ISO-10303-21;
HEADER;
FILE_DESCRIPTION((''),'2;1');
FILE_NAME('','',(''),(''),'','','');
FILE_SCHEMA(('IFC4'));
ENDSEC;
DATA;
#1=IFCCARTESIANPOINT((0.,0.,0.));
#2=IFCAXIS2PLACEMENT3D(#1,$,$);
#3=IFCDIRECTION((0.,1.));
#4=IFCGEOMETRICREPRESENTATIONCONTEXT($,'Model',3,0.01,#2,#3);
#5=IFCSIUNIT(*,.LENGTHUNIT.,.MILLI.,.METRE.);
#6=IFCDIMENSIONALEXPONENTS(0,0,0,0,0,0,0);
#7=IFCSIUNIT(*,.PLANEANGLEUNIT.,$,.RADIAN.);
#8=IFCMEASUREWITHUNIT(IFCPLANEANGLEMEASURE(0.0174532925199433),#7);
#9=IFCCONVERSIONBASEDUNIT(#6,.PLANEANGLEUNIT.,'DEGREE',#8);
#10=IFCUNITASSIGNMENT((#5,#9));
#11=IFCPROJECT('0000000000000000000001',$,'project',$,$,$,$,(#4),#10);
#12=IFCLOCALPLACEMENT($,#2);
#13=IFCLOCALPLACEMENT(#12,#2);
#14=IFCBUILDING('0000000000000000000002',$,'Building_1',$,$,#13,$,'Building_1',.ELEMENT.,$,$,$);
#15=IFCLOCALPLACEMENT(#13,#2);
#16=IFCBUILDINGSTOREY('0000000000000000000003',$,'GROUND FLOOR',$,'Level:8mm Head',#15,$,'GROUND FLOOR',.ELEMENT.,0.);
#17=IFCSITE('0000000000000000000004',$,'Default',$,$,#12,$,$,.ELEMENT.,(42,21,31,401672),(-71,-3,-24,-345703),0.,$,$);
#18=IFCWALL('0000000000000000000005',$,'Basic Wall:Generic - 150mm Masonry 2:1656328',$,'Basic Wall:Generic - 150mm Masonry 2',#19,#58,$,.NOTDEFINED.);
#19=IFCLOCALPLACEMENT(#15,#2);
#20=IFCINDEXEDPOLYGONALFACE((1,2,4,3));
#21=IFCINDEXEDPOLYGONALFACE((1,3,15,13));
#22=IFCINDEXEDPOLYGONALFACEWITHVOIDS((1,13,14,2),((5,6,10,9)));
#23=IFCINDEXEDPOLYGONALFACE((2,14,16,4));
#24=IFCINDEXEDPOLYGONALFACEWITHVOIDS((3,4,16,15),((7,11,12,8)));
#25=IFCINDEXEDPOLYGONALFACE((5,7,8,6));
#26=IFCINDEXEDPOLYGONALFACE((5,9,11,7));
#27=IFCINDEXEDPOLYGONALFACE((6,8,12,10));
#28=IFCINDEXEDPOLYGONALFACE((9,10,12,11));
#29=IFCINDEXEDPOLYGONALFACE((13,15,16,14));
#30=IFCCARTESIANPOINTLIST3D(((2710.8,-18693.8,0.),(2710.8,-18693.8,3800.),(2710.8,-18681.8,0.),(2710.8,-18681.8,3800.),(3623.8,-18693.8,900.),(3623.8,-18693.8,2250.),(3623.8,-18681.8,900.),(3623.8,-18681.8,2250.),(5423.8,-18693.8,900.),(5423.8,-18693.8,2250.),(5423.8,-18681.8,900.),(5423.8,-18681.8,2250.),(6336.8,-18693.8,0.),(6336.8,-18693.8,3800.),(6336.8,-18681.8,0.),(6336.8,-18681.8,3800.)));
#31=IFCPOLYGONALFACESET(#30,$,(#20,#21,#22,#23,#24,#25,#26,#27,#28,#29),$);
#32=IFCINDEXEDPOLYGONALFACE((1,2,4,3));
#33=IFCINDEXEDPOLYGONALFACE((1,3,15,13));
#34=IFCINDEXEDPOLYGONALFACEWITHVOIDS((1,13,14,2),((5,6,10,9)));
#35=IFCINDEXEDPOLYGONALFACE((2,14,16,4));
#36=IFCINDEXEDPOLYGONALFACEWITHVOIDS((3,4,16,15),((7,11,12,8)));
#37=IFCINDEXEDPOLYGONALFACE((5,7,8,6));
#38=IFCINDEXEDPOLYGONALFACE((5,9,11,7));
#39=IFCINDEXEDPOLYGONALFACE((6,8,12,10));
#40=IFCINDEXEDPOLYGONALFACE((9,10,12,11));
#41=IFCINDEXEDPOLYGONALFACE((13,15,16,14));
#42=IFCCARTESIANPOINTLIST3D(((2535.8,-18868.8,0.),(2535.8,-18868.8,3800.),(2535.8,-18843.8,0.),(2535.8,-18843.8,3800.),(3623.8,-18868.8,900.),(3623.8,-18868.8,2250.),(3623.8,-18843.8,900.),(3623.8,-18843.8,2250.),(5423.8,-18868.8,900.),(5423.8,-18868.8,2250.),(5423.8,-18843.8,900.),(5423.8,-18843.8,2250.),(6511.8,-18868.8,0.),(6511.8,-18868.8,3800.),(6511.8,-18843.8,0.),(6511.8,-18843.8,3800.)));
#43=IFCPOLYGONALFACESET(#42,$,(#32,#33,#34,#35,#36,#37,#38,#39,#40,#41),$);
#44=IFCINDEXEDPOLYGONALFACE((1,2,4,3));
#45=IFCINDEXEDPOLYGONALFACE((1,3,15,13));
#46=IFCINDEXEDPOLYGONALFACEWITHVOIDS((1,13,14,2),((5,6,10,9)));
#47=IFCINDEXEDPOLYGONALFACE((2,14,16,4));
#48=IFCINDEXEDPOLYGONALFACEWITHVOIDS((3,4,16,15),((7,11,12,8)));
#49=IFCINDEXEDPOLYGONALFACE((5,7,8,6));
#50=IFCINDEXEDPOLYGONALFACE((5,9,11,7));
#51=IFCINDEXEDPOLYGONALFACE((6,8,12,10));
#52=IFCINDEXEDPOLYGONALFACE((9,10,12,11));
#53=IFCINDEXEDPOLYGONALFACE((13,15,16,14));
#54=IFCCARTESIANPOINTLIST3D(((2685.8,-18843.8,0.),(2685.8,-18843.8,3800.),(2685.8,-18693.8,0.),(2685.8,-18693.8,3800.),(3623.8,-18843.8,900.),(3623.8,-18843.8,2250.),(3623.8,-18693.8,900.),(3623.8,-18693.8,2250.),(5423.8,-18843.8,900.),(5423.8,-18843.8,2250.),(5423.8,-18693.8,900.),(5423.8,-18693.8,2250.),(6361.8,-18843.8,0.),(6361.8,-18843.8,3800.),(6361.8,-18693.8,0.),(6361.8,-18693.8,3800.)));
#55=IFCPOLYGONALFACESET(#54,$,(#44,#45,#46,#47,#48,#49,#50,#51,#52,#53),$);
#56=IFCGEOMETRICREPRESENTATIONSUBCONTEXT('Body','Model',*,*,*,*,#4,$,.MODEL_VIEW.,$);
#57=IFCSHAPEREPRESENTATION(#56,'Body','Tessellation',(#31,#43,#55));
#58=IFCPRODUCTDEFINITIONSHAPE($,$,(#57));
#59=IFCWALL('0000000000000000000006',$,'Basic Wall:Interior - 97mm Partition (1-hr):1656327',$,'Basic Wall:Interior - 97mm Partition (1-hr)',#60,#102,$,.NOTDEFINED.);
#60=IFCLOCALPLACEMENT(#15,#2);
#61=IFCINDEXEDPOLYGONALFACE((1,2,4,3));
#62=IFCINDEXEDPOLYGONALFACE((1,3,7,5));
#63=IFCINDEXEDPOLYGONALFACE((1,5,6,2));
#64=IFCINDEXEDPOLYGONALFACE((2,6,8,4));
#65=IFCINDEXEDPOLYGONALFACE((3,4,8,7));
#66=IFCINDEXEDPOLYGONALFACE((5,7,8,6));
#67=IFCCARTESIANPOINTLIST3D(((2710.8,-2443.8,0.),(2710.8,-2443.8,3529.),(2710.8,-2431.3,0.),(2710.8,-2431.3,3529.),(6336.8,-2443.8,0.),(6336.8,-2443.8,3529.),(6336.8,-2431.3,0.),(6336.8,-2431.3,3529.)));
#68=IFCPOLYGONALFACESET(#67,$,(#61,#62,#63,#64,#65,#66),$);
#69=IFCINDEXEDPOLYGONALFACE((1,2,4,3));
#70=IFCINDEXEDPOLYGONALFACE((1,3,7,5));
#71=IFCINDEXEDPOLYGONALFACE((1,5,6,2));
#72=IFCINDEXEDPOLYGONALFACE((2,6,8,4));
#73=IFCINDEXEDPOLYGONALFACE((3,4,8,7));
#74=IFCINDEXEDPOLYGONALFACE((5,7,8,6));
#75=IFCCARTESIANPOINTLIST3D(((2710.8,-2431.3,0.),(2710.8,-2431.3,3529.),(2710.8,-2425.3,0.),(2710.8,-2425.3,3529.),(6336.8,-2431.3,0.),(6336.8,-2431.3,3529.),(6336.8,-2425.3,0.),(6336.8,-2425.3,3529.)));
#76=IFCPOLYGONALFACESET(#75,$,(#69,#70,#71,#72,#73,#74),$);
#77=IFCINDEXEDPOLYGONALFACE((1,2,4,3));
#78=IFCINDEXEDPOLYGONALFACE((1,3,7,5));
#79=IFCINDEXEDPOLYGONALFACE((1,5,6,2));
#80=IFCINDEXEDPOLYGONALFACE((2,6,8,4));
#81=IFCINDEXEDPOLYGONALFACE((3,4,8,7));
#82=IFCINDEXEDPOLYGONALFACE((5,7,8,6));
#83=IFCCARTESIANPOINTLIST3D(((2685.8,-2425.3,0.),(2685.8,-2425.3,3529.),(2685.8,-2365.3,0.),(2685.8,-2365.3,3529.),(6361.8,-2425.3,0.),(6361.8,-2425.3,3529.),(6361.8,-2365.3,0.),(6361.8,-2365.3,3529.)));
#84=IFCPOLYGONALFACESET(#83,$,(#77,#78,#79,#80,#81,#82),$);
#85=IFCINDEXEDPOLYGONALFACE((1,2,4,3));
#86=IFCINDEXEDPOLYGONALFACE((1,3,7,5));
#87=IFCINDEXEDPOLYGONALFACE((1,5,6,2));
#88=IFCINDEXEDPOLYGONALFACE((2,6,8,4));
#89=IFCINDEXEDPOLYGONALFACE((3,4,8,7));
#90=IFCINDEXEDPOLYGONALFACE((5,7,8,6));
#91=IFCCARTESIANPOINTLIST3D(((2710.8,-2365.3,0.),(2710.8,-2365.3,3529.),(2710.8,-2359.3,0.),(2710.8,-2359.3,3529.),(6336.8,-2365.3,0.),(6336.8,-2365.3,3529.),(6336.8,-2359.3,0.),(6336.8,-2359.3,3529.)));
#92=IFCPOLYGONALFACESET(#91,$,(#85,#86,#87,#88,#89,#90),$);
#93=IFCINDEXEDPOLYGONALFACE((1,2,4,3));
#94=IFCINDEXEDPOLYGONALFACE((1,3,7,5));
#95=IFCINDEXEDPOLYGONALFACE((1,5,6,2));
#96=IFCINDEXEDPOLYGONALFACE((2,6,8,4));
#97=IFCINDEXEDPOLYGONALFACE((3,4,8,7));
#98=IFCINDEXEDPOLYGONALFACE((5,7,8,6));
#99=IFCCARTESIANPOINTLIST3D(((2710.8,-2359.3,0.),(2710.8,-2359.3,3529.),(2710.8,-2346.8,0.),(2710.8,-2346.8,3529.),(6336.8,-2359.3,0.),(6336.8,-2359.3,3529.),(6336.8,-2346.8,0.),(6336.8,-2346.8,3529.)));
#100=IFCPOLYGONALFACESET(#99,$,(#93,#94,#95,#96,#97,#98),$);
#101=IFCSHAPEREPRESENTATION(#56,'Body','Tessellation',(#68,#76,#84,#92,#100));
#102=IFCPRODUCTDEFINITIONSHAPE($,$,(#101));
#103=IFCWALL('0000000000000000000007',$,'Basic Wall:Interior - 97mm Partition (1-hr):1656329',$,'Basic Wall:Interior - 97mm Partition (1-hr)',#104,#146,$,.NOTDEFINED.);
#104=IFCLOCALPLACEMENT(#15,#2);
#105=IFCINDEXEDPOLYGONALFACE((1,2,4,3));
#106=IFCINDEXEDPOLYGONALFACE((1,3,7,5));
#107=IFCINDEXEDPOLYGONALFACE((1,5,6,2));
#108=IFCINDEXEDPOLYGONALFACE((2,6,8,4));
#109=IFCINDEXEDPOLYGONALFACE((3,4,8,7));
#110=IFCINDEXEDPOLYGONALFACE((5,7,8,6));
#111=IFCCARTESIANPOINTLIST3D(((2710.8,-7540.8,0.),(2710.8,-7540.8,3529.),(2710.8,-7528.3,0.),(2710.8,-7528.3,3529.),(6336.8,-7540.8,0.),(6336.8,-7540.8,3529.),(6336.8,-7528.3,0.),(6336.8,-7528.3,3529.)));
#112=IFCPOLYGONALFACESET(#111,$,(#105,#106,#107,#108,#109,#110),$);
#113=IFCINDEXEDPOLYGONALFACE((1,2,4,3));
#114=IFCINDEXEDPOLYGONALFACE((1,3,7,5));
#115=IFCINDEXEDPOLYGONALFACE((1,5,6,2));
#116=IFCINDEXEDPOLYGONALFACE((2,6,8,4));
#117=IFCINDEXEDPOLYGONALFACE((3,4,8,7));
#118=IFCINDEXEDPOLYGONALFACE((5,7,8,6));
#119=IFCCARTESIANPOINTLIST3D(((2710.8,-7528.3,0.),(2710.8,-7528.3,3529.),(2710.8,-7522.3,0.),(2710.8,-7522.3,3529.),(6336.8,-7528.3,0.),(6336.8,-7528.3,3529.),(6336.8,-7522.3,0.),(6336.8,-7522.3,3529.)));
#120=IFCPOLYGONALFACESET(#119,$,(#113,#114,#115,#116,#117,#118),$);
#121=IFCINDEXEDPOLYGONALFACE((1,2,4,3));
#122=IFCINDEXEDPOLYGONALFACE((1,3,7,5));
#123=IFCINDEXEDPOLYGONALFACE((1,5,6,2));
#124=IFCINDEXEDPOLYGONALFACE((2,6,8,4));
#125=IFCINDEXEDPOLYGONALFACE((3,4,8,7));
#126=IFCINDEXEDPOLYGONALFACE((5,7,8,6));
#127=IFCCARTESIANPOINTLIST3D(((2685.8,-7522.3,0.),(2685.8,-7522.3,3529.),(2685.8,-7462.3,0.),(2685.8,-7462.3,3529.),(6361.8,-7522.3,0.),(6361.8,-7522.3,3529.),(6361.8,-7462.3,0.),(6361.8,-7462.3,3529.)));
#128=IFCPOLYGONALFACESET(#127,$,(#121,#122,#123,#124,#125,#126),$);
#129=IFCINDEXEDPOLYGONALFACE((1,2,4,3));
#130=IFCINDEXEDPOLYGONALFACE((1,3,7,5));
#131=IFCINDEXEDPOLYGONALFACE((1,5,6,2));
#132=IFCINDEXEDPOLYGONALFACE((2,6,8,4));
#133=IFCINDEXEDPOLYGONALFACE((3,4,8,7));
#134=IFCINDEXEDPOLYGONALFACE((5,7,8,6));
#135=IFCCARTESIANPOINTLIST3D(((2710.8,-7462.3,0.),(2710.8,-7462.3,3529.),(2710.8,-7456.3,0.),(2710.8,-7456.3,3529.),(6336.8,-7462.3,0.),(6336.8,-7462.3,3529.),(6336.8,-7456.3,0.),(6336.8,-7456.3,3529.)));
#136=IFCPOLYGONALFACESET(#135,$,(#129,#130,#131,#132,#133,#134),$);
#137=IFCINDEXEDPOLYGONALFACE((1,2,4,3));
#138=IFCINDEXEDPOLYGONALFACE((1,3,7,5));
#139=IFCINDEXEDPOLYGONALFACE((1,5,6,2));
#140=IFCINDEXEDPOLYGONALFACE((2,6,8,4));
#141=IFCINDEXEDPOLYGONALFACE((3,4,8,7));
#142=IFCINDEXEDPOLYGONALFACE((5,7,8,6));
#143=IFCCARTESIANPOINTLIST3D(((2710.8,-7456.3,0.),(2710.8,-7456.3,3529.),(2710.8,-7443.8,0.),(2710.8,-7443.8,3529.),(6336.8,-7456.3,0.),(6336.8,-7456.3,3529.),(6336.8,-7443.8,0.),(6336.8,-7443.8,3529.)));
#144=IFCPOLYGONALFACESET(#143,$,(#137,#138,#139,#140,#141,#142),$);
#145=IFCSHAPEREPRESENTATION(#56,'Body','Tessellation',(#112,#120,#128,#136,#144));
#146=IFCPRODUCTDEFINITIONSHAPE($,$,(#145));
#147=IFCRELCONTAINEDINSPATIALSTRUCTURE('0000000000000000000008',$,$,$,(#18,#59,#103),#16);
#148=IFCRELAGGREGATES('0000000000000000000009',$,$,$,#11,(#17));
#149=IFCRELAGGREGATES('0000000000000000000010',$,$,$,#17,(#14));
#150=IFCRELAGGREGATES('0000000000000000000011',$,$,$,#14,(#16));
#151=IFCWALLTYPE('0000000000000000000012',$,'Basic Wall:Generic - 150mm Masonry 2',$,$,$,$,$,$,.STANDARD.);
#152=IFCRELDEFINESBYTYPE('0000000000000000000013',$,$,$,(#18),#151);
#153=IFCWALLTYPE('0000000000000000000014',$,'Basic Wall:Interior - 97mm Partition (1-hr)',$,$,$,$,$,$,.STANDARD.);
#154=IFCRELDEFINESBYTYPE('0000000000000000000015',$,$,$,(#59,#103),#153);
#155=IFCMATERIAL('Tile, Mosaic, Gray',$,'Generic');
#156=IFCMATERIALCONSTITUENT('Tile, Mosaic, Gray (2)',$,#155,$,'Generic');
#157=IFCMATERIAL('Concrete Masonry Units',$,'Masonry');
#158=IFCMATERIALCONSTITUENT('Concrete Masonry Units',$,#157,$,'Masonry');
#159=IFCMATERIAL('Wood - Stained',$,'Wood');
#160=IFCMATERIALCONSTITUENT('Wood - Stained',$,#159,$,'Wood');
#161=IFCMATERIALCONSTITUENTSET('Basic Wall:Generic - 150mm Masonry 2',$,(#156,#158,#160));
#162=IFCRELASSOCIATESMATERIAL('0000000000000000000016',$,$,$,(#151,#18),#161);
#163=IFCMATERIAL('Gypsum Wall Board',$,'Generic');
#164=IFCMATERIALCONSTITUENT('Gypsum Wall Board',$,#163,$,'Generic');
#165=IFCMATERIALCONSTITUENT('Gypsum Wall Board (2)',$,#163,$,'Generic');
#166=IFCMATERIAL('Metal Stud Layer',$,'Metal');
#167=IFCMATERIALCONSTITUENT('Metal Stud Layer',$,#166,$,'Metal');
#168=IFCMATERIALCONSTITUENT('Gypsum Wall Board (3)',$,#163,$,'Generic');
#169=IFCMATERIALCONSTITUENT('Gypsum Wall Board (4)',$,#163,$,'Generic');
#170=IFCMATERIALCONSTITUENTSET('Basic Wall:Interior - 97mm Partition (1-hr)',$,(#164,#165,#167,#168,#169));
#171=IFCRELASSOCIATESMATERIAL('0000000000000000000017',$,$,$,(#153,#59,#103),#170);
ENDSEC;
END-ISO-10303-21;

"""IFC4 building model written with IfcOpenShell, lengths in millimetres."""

from ifc_helpers import new_model, entity, si_unit, converted_unit, direction, frame, origin, place, context, subcontext, project, spatial, indexed_curve, outline, extrude, material, constituent, constituent_set, type_object, element, save


model = new_model("IFC4")

# Units and contexts
model_context = context("Model", 3, precision=0.01, world=origin(), true_north=direction((0.0, 1.0)))
body_context = subcontext(model_context, "Body", "Model", "MODEL_VIEW")
ifc_project = project(units=[si_unit("LENGTHUNIT", "METRE", prefix="MILLI"), converted_unit("PLANEANGLEUNIT", "DEGREE", entity("IfcPlaneAngleMeasure", 0.0174532925199433), si_unit("PLANEANGLEUNIT", "RADIAN"), dimensions=[0, 0, 0, 0, 0, 0, 0])], contexts=[model_context])

# Site, building, storey
site_placement = place(None, origin())
site = spatial("IfcSite", under=ifc_project, at=site_placement, Name="Default", CompositionType="ELEMENT", RefLatitude=(42, 21, 31, 401672), RefLongitude=(-71, -3, -24, -345703), RefElevation=0.0)
building_placement = place(site_placement, origin())
building = spatial("IfcBuilding", under=site, at=building_placement, Name="Building_1", LongName="Building_1", CompositionType="ELEMENT")
storey_placement = place(building_placement, origin())
storey = spatial("IfcBuildingStorey", under=building, at=storey_placement, Name="GROUND FLOOR", ObjectType="Level:8mm Head", LongName="GROUND FLOOR", CompositionType="ELEMENT", Elevation=0.0)

# Shared definitions
ifc_material_1 = material(Name="Tile, Mosaic, Gray", Category="Generic")
ifc_constituent_1 = constituent(ifc_material_1, Name="Tile, Mosaic, Gray (2)", Category="Generic")
ifc_material_2 = material(Name="Concrete Masonry Units", Category="Masonry")
ifc_constituent_2 = constituent(ifc_material_2, Name="Concrete Masonry Units", Category="Masonry")
ifc_material_3 = material(Name="Wood - Stained", Category="Wood")
ifc_constituent_3 = constituent(ifc_material_3, Name="Wood - Stained", Category="Wood")
ifc_constituent_set_1 = constituent_set(constituents=[ifc_constituent_1, ifc_constituent_2, ifc_constituent_3], Name="Basic Wall:Generic - 150mm Masonry 2")
wall_type_1 = type_object("IfcWallType", Name="Basic Wall:Generic - 150mm Masonry 2", PredefinedType="STANDARD", material=ifc_constituent_set_1)

# Wall, opening
wall_1_placement = place(storey_placement, frame((2710.8, -18775.3, 0.0)))
wall_1 = element("IfcWall", 1, at=wall_1_placement, inside=storey, type_object=wall_type_1, material=ifc_constituent_set_1, Name="Basic Wall:Generic - 150mm Masonry 2:1656328", ObjectType="Basic Wall:Generic - 150mm Masonry 2", PredefinedType="NOTDEFINED", context=body_context, shape_type="SweptSolid", body=[
    extrude(outline(indexed_curve([(-1900.0, -1813.0), (1900.0, -1813.0), (1900.0, 1813.0), (-1900.0, 1813.0), (-1900.0, -1813.0)], self_intersect=False), holes=[indexed_curve([(350.0, 900.0), (350.0, -900.0), (-1000.0, -900.0), (-1000.0, 900.0), (350.0, 900.0)], self_intersect=False)]), frame((1813.0, 81.5, 1900.0), z_axis=(0.0, 1.0, 0.0), x_axis=(0.0, 0.0, 1.0)), (0.0, 0.0, 1.0), 12.0),
    extrude(outline(indexed_curve([(-1900.0, -1988.0), (1900.0, -1988.0), (1900.0, 1988.0), (-1900.0, 1988.0), (-1900.0, -1988.0)], self_intersect=False), holes=[indexed_curve([(350.0, 900.0), (350.0, -900.0), (-1000.0, -900.0), (-1000.0, 900.0), (350.0, 900.0)], self_intersect=False)]), frame((1813.0, -93.5, 1900.0), z_axis=(0.0, 1.0, 0.0), x_axis=(0.0, 0.0, 1.0)), (0.0, 0.0, 1.0), 25.0),
    extrude(outline(indexed_curve([(-1900.0, -1838.0), (1900.0, -1838.0), (1900.0, 1838.0), (-1900.0, 1838.0), (-1900.0, -1838.0)], self_intersect=False), holes=[indexed_curve([(350.0, 900.0), (350.0, -900.0), (-1000.0, -900.0), (-1000.0, 900.0), (350.0, 900.0)], self_intersect=False)]), frame((1813.0, -68.5, 1900.0), z_axis=(0.0, 1.0, 0.0), x_axis=(0.0, 0.0, 1.0)), (0.0, 0.0, 1.0), 150.0),
])
opening_1_placement = place(wall_1_placement, frame((2713.0, 93.5, 900.0)))
element("IfcOpeningElement", 2, at=opening_1_placement, cuts=wall_1, PredefinedType="OPENING", context=body_context, shape_type="SweptSolid", body=[
    extrude(outline(indexed_curve([(1350.0, 0.0), (1350.0, 1800.0), (0.0, 1800.0), (0.0, 0.0), (1350.0, 0.0)], self_intersect=False)), frame((0.0, 0.0, 0.0), z_axis=(0.0, -1.0, 0.0), x_axis=(0.0, 0.0, 1.0)), (0.0, 0.0, 1.0), 187.0),
])

# Walls
ifc_material_4 = material(Name="Gypsum Wall Board", Category="Generic")
ifc_constituent_4 = constituent(ifc_material_4, Name="Gypsum Wall Board", Category="Generic")
ifc_constituent_5 = constituent(ifc_material_4, Name="Gypsum Wall Board (2)", Category="Generic")
ifc_material_5 = material(Name="Metal Stud Layer", Category="Metal")
ifc_constituent_6 = constituent(ifc_material_5, Name="Metal Stud Layer", Category="Metal")
ifc_constituent_7 = constituent(ifc_material_4, Name="Gypsum Wall Board (3)", Category="Generic")
ifc_constituent_8 = constituent(ifc_material_4, Name="Gypsum Wall Board (4)", Category="Generic")
ifc_constituent_set_2 = constituent_set(constituents=[ifc_constituent_4, ifc_constituent_5, ifc_constituent_6, ifc_constituent_7, ifc_constituent_8], Name="Basic Wall:Interior - 97mm Partition (1-hr)")
wall_type_2 = type_object("IfcWallType", Name="Basic Wall:Interior - 97mm Partition (1-hr)", PredefinedType="STANDARD", material=ifc_constituent_set_2)
wall_2_placement = place(storey_placement, frame((6336.8, -2395.3, 0.0), z_axis=(0.0, 0.0, 1.0), x_axis=(-1.0, 0.0, 0.0)))
element("IfcWall", 3, at=wall_2_placement, inside=storey, type_object=wall_type_2, material=ifc_constituent_set_2, Name="Basic Wall:Interior - 97mm Partition (1-hr):1656327", ObjectType="Basic Wall:Interior - 97mm Partition (1-hr)", PredefinedType="NOTDEFINED", context=body_context, shape_type="SweptSolid", body=[
    extrude(outline(indexed_curve([(-6.2, -1764.5), (6.3, -1764.5), (6.2, 1764.5), (-6.2, 1764.5), (-6.2, -1764.5)], self_intersect=False)), frame((3626.0, 42.3, 1764.5), z_axis=(-1.0, 0.0, 0.0), x_axis=(0.0, -1.0, 0.0)), (0.0, 0.0, 1.0), 3626.0),
    extrude(outline(indexed_curve([(-1764.5, -3.0), (1764.5, -3.0), (1764.5, 3.0), (-1764.5, 3.0), (-1764.5, -3.0)], self_intersect=False)), frame((3626.0, 33.0, 1764.5), z_axis=(-1.0, 0.0, 0.0), x_axis=(0.0, 0.0, 1.0)), (0.0, 0.0, 1.0), 3626.0),
    extrude(outline(indexed_curve([(-1764.5, -30.0), (1764.5, -30.0), (1764.5, 30.0), (-1764.5, 30.0), (-1764.5, -30.0)], self_intersect=False)), frame((3651.0, 0.0, 1764.5), z_axis=(-1.0, 0.0, 0.0), x_axis=(0.0, 0.0, 1.0)), (0.0, 0.0, 1.0), 3676.0),
    extrude(outline(indexed_curve([(-1764.5, -3.0), (1764.5, -3.0), (1764.5, 3.0), (-1764.5, 3.0), (-1764.5, -3.0)], self_intersect=False)), frame((3626.0, -33.0, 1764.5), z_axis=(-1.0, 0.0, 0.0), x_axis=(0.0, 0.0, 1.0)), (0.0, 0.0, 1.0), 3626.0),
    extrude(outline(indexed_curve([(-6.3, -1764.5), (6.3, -1764.5), (6.3, 1764.5), (-6.3, 1764.5), (-6.3, -1764.5)], self_intersect=False)), frame((3626.0, -42.3, 1764.5), z_axis=(-1.0, 0.0, 0.0), x_axis=(0.0, 1.0, 0.0)), (0.0, 0.0, 1.0), 3626.0),
])
wall_3_placement = place(storey_placement, frame((6336.8, -7492.3, 0.0), z_axis=(0.0, 0.0, 1.0), x_axis=(-1.0, 0.0, 0.0)))
element("IfcWall", 4, at=wall_3_placement, inside=storey, type_object=wall_type_2, material=ifc_constituent_set_2, Name="Basic Wall:Interior - 97mm Partition (1-hr):1656329", ObjectType="Basic Wall:Interior - 97mm Partition (1-hr)", PredefinedType="NOTDEFINED", context=body_context, shape_type="SweptSolid", body=[
    extrude(outline(indexed_curve([(-6.2, -1764.5), (6.2, -1764.5), (6.3, 1764.5), (-6.2, 1764.5), (-6.2, -1764.5)], self_intersect=False)), frame((3626.0, 42.3, 1764.5), z_axis=(-1.0, 0.0, 0.0), x_axis=(0.0, -1.0, 0.0)), (0.0, 0.0, 1.0), 3626.0),
    extrude(outline(indexed_curve([(-1764.5, -3.0), (1764.5, -3.0), (1764.5, 3.0), (-1764.5, 3.0), (-1764.5, -3.0)], self_intersect=False)), frame((3626.0, 33.0, 1764.5), z_axis=(-1.0, 0.0, 0.0), x_axis=(0.0, 0.0, 1.0)), (0.0, 0.0, 1.0), 3626.0),
    extrude(outline(indexed_curve([(-1764.5, -30.0), (1764.5, -30.0), (1764.5, 30.0), (-1764.5, 30.0), (-1764.5, -30.0)], self_intersect=False)), frame((3651.0, 0.0, 1764.5), z_axis=(-1.0, 0.0, 0.0), x_axis=(0.0, 0.0, 1.0)), (0.0, 0.0, 1.0), 3676.0),
    extrude(outline(indexed_curve([(-1764.5, -3.0), (1764.5, -3.0), (1764.5, 3.0), (-1764.5, 3.0), (-1764.5, -3.0)], self_intersect=False)), frame((3626.0, -33.0, 1764.5), z_axis=(-1.0, 0.0, 0.0), x_axis=(0.0, 0.0, 1.0)), (0.0, 0.0, 1.0), 3626.0),
    extrude(outline(indexed_curve([(-6.2, -1764.5), (6.3, -1764.5), (6.2, 1764.5), (-6.3, 1764.5), (-6.2, -1764.5)], self_intersect=False)), frame((3626.0, -42.3, 1764.5), z_axis=(-1.0, 0.0, 0.0), x_axis=(0.0, 1.0, 0.0)), (0.0, 0.0, 1.0), 3626.0),
])

save(model, "model.ifc")
